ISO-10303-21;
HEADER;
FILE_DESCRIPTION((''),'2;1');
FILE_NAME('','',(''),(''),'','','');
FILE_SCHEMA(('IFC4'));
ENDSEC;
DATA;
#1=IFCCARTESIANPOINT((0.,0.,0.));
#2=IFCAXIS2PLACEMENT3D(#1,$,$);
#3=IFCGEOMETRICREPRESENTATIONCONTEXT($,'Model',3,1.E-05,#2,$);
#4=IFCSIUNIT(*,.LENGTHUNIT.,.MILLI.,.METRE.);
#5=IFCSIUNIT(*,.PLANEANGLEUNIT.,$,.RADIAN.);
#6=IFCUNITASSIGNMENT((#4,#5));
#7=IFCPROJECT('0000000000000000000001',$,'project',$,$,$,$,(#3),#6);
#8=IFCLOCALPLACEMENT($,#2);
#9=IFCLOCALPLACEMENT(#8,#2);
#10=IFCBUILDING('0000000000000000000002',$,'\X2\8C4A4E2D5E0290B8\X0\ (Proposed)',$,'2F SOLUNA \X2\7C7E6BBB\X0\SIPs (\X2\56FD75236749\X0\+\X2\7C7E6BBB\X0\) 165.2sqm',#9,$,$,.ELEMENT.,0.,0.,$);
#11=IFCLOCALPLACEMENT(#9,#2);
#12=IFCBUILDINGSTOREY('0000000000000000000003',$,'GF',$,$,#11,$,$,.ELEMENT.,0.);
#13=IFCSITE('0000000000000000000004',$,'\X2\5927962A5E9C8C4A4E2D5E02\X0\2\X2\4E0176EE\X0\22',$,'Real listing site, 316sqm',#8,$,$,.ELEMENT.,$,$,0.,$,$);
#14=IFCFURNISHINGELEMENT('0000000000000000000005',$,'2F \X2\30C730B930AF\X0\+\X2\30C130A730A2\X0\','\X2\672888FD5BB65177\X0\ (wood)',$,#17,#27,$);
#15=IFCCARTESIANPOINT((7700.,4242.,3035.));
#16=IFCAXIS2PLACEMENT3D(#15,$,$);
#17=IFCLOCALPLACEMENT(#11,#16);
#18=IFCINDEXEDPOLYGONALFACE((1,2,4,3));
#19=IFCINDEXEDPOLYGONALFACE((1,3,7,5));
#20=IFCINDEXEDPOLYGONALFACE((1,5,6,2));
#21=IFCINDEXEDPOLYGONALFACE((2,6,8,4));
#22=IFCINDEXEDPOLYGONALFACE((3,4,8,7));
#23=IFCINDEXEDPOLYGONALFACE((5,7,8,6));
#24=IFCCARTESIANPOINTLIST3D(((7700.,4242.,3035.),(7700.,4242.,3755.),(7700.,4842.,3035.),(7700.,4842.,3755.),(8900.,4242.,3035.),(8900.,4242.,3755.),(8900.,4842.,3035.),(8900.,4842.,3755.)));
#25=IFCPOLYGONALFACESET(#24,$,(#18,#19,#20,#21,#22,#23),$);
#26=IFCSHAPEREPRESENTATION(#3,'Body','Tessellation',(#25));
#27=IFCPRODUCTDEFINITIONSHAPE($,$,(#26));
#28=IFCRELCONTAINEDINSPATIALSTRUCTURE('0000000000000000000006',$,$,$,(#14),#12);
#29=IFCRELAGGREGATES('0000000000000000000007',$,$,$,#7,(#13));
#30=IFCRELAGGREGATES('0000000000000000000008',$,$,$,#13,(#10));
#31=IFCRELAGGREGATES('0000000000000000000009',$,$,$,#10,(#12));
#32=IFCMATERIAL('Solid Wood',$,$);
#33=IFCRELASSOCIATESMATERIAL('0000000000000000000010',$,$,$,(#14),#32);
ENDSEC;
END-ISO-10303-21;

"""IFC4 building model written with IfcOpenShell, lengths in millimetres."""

from ifc_helpers import new_model, si_unit, frame, frame_2d, origin, place, context, project, spatial, rectangle, extrude, material, element, save


model = new_model("IFC4")

# Units and contexts
model_context = context("Model", 3, precision=1e-05, world=origin())
ifc_project = project(units=[si_unit("LENGTHUNIT", "METRE", prefix="MILLI"), si_unit("PLANEANGLEUNIT", "RADIAN")], contexts=[model_context])

# Site, building, storey
site_placement = place(None, origin())
site = spatial("IfcSite", under=ifc_project, at=site_placement, Name="大阪府豊中市2丁目22", ObjectType="Real listing site, 316sqm", CompositionType="ELEMENT", RefElevation=0.0)
building_placement = place(site_placement, origin())
building = spatial("IfcBuilding", under=site, at=building_placement, Name="豊中市邸 (Proposed)", ObjectType="2F SOLUNA 籾殻SIPs (国産杉+籾殻) 165.2sqm", CompositionType="ELEMENT", ElevationOfRefHeight=0.0, ElevationOfTerrain=0.0)
storey_placement = place(building_placement, origin())
storey = spatial("IfcBuildingStorey", under=building, at=storey_placement, Name="GF", CompositionType="ELEMENT", Elevation=0.0)

# Shared definitions
ifc_material_1 = material(Name="Solid Wood")

# Furnishing element
furnishing_1_placement = place(storey_placement, frame((7700.0, 4242.0, 3035.0)))
element("IfcFurnishingElement", 1, at=furnishing_1_placement, inside=storey, material=ifc_material_1, Name="2F デスク+チェア", Description="木製家具 (wood)", context=model_context, shape_type="SweptSolid", body=[
    extrude(rectangle(XDim=1200.0, YDim=600.0, at=frame_2d((600.0, 300.0))), frame((7700.0, 4242.0, 3035.0)), (0.0, 0.0, 1.0), 720.0),
])

save(model, "model.ifc")
